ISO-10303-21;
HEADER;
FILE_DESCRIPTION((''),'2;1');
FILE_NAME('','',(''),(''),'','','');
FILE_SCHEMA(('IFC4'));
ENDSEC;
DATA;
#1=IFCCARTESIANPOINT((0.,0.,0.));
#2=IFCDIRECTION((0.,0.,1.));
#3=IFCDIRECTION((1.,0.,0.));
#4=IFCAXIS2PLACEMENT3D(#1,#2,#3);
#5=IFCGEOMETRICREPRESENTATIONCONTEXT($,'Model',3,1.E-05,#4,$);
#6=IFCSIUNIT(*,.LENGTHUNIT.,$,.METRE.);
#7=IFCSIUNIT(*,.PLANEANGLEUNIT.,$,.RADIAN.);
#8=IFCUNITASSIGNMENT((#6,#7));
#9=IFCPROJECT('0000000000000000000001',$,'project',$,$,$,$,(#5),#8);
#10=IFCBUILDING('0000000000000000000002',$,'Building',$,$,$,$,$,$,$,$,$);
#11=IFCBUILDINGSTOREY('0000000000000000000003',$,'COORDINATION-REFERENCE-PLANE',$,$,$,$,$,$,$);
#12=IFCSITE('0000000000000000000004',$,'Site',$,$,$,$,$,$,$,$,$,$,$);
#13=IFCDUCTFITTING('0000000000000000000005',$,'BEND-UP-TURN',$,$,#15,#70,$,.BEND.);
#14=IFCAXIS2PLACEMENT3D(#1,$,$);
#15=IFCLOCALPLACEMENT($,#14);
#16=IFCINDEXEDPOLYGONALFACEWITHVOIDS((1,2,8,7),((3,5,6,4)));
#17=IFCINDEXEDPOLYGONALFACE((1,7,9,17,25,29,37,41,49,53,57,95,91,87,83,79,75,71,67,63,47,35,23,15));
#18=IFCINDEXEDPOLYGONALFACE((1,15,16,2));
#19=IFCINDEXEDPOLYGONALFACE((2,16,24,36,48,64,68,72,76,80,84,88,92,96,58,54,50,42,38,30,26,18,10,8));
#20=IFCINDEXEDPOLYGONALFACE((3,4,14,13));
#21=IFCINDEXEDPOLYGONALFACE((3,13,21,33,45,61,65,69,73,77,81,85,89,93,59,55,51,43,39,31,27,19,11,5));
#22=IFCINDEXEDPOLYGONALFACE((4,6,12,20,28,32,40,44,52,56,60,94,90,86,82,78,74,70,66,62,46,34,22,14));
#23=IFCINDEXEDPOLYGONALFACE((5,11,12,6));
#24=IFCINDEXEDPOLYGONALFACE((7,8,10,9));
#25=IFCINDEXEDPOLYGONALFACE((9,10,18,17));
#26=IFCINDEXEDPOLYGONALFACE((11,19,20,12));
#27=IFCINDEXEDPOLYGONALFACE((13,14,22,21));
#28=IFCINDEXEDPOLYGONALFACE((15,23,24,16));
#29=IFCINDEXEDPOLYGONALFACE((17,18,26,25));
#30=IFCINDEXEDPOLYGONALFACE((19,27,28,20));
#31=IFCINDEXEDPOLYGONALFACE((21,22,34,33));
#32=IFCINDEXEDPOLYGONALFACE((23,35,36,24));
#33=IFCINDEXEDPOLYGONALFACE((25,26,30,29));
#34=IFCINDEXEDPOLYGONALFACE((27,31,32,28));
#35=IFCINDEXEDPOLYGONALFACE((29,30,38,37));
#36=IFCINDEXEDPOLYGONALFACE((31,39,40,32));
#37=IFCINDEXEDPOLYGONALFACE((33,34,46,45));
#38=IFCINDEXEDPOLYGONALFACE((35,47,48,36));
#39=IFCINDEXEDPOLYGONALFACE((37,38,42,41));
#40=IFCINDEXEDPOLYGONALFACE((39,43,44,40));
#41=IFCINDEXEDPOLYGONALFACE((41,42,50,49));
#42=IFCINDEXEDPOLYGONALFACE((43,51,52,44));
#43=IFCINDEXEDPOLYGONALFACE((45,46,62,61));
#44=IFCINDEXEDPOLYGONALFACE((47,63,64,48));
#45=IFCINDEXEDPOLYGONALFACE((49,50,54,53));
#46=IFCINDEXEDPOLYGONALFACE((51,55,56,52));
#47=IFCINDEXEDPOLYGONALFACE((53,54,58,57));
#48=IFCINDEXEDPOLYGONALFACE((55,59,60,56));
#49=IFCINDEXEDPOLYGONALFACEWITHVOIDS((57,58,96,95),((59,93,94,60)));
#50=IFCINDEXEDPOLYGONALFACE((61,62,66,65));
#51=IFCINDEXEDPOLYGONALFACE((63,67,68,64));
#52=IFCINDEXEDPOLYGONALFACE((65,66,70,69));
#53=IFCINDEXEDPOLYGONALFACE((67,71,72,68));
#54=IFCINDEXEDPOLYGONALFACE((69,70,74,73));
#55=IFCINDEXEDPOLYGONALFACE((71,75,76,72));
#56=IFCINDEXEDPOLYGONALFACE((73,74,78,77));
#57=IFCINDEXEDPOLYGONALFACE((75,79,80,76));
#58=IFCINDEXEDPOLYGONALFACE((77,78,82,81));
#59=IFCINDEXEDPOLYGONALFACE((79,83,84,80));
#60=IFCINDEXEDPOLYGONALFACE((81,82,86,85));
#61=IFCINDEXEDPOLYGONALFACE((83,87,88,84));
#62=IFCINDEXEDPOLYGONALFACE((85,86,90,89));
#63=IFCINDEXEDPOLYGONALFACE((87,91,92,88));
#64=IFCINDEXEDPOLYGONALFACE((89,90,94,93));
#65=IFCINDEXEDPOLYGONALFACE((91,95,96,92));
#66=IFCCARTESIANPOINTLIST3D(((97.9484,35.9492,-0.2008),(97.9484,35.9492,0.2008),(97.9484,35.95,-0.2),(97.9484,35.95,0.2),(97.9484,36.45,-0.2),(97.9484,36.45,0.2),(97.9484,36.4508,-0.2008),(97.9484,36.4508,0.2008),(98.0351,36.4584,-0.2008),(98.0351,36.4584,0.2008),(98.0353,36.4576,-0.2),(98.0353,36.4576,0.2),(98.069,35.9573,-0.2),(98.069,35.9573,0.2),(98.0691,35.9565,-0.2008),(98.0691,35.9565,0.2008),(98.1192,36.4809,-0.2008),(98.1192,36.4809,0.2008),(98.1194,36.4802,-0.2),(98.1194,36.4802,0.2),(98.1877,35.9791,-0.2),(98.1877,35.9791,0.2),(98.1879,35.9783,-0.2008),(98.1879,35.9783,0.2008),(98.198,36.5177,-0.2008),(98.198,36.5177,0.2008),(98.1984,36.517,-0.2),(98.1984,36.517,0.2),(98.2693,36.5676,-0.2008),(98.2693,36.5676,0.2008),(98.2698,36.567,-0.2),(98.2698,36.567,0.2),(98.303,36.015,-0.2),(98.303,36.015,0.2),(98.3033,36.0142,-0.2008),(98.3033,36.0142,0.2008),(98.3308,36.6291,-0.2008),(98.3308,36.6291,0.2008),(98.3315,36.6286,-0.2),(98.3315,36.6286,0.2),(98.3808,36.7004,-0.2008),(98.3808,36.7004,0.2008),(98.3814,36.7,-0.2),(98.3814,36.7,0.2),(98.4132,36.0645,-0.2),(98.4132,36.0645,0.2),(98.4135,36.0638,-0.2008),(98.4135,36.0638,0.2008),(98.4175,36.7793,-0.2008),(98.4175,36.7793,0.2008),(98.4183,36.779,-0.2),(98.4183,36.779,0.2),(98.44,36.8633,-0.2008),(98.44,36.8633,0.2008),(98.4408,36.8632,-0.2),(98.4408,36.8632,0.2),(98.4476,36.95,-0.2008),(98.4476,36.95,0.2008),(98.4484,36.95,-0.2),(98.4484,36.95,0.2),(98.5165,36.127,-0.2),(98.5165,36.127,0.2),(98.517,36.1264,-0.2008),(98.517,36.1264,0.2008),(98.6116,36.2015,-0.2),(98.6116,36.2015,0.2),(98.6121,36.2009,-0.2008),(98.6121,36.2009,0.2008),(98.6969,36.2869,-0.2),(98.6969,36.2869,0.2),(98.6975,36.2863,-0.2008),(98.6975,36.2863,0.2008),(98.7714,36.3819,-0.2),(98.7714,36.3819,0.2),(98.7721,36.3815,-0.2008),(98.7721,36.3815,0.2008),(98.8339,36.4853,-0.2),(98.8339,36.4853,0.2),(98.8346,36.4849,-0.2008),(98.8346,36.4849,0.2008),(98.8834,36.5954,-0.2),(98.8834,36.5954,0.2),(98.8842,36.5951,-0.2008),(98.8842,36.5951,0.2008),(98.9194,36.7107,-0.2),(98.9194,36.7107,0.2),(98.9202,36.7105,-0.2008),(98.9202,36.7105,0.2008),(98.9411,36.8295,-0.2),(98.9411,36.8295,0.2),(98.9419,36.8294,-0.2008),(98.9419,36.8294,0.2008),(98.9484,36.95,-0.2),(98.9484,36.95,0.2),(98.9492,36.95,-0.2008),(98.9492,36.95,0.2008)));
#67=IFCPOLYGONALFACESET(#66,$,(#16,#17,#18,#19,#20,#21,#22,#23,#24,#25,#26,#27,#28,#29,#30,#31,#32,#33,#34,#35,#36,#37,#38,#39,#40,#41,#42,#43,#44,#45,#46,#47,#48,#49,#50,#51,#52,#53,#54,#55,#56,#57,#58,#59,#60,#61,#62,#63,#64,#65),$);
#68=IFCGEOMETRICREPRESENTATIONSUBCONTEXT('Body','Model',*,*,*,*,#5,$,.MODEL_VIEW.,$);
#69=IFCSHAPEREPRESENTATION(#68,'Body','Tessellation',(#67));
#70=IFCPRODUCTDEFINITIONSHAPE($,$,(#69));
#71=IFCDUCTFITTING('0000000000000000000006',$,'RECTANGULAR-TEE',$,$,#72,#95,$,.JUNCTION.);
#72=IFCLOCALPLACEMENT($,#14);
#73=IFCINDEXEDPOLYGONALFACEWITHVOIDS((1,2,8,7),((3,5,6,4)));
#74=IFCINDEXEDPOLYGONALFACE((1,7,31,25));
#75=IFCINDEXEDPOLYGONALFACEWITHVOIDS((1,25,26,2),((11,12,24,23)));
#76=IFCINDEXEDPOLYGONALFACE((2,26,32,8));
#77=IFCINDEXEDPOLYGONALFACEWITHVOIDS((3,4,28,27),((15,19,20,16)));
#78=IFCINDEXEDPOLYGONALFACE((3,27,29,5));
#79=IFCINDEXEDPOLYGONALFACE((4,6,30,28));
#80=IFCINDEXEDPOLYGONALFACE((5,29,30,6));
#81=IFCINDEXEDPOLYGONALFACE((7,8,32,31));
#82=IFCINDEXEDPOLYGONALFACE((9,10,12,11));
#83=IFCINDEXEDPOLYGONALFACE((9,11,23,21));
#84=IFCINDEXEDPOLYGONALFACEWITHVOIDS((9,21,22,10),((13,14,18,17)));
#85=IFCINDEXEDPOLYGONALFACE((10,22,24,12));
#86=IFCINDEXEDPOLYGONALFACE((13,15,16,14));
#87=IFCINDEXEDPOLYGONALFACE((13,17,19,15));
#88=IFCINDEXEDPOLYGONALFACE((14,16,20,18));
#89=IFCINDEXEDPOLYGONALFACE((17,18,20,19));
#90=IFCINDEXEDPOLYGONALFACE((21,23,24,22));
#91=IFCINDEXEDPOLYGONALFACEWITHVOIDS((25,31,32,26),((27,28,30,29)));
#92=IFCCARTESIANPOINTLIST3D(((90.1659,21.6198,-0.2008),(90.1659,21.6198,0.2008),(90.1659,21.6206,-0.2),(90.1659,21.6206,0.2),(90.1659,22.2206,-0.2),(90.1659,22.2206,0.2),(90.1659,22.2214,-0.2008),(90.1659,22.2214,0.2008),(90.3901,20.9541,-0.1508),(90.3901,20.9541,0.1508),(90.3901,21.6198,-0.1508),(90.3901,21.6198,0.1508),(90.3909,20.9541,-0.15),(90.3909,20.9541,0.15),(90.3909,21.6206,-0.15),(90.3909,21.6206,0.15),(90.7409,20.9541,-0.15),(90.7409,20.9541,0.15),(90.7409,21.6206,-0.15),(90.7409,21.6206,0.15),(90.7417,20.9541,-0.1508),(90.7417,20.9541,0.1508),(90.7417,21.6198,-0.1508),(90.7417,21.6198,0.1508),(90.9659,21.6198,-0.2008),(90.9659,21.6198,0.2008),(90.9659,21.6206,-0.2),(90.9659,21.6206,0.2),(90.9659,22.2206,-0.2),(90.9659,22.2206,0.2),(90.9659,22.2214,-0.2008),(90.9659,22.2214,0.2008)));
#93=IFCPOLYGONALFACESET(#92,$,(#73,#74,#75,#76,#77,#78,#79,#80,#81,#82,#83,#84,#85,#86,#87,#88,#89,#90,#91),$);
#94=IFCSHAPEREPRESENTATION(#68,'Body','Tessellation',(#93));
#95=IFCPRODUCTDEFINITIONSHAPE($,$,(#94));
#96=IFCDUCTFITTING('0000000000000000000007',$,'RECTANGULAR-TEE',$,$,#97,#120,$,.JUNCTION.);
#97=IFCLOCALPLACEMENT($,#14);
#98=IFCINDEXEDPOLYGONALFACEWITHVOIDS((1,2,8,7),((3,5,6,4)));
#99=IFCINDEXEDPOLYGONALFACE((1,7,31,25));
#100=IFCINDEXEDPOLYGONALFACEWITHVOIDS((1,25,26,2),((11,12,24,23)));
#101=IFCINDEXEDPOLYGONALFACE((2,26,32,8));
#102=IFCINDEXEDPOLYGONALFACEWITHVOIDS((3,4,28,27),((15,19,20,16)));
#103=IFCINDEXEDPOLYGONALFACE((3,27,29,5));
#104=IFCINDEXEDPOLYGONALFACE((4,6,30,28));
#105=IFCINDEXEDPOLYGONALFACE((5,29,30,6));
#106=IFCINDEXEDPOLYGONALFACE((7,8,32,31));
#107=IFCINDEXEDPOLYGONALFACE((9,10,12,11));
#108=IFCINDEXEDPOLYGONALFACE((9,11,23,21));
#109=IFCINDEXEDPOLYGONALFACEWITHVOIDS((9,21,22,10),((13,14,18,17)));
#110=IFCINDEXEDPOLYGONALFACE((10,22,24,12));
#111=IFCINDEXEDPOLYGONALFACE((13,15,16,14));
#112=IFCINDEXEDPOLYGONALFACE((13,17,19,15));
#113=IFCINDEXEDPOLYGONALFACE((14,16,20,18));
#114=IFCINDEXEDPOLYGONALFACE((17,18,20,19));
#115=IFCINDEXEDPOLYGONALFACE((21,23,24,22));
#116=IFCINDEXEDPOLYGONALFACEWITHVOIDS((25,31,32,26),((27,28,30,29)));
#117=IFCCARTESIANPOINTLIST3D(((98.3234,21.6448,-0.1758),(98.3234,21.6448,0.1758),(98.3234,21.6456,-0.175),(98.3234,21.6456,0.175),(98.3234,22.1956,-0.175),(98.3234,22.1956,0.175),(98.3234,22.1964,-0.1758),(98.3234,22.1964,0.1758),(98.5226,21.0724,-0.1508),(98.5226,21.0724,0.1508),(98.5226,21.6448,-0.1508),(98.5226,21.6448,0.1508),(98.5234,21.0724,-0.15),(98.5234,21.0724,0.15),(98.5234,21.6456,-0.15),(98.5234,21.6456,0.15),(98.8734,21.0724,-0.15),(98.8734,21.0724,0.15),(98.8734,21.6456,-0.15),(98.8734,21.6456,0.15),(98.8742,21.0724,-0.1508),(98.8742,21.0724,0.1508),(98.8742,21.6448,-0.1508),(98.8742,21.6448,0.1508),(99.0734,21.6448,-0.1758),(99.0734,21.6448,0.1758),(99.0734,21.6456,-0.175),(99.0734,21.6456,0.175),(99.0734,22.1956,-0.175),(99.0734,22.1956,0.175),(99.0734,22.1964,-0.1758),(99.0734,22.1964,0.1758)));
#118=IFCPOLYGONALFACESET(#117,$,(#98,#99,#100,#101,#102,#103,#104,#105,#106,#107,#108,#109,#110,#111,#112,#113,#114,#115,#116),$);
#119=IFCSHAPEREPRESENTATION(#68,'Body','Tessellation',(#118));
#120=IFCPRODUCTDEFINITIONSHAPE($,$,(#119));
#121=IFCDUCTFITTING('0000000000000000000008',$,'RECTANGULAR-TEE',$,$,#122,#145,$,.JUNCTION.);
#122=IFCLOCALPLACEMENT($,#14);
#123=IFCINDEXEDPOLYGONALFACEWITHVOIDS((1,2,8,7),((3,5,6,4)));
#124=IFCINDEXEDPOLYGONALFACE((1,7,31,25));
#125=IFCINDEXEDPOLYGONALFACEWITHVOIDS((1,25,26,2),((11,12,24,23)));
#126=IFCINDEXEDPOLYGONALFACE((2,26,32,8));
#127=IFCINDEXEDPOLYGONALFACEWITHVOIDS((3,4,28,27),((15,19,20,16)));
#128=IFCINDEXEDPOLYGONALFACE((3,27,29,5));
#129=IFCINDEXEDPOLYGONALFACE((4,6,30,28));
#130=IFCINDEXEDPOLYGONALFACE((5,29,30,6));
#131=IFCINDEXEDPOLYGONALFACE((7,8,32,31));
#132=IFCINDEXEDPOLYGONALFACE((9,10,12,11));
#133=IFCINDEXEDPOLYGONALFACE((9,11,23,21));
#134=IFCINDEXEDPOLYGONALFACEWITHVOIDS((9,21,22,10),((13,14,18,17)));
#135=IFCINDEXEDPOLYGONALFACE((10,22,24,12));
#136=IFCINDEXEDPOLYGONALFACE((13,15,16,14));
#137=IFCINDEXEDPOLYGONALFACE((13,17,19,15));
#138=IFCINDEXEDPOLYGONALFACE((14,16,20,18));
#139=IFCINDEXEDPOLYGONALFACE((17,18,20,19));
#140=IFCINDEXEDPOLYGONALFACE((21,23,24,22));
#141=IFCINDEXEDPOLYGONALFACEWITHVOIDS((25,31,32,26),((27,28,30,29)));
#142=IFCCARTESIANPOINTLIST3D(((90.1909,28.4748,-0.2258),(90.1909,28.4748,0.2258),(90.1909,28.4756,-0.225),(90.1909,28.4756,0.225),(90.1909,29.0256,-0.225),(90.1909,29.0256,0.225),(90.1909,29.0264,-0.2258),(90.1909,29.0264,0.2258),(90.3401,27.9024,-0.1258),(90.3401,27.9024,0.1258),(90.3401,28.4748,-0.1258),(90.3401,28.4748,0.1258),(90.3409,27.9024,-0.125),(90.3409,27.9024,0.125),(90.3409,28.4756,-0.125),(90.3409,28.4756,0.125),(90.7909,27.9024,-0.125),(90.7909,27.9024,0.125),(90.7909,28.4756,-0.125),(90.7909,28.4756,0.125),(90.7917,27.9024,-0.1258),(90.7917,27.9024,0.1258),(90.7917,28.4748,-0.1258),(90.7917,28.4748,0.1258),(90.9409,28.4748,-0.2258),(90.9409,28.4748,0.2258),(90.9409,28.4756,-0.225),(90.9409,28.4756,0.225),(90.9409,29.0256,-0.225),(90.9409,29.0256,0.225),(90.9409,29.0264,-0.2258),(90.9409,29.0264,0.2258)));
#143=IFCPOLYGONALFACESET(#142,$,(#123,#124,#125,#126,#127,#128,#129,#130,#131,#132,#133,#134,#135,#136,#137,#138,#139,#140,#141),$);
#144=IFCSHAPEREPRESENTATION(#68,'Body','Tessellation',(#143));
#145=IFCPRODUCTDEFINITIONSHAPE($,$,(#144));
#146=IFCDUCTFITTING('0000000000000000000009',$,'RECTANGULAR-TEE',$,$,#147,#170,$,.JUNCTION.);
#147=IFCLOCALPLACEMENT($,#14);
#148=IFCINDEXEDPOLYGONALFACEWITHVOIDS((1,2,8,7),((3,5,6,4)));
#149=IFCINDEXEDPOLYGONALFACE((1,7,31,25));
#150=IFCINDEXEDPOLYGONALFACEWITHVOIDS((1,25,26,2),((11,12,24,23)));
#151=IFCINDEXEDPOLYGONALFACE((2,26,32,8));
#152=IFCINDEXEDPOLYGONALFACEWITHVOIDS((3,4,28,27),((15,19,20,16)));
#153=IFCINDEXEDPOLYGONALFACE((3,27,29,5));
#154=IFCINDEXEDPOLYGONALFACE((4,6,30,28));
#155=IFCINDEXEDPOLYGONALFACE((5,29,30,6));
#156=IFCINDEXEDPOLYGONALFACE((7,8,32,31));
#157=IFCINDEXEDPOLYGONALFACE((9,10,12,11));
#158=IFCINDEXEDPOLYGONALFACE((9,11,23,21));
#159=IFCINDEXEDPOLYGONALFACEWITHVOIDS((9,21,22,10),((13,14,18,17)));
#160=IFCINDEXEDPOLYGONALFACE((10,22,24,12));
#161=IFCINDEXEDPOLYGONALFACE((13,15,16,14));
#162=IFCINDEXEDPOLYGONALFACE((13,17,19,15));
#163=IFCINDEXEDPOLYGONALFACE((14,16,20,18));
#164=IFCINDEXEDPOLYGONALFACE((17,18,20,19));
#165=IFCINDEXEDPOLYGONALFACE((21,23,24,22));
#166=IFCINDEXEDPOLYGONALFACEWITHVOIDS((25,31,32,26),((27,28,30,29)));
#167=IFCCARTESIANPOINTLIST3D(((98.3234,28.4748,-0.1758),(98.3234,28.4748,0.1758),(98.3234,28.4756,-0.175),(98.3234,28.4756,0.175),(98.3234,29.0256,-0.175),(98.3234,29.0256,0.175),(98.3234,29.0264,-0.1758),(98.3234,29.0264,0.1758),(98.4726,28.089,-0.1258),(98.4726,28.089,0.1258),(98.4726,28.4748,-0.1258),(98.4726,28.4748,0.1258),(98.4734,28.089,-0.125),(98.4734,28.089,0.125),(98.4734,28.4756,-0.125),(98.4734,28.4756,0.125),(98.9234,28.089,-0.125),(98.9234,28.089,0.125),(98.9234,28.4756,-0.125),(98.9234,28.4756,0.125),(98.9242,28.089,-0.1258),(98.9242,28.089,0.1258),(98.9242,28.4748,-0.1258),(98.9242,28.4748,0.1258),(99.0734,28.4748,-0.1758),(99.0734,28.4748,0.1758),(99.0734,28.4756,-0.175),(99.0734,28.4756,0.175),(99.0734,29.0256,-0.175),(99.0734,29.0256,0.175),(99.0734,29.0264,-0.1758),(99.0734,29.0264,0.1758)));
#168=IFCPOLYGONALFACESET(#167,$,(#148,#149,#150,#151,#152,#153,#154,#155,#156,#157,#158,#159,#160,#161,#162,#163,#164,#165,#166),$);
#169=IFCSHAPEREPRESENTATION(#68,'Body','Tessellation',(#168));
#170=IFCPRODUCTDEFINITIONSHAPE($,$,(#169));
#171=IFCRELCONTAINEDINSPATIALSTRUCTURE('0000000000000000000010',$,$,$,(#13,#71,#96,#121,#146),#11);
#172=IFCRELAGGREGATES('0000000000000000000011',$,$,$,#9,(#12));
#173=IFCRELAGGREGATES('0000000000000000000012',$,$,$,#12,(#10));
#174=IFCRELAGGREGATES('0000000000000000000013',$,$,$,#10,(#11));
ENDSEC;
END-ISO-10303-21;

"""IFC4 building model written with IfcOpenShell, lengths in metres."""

from ifc_helpers import new_model, entity, si_unit, frame, origin_with_axes, place, context, subcontext, project, spatial, rectangle, extrude, boolean, element, save


model = new_model("IFC4")

# Units and contexts
model_context = context("Model", 3, precision=1e-05, world=origin_with_axes())
body_context = subcontext(model_context, "Body", "Model", "MODEL_VIEW")
ifc_project = project(units=[si_unit("LENGTHUNIT", "METRE"), si_unit("PLANEANGLEUNIT", "RADIAN")], contexts=[model_context])

# Site, building, storey
site = spatial("IfcSite", under=ifc_project, Name="Site")
building = spatial("IfcBuilding", under=site, Name="Building")
storey = spatial("IfcBuildingStorey", under=building, Name="COORDINATION-REFERENCE-PLANE")

# Duct fittings
duct_fitting_1_placement = place(None, frame((97.9484, 36.95, 0.0), z_axis=(0.0, 0.0, 1.0), x_axis=(0.0, -1.0, 0.0)))
cartesian_point_1 = entity("IfcCartesianPoint", [0.0, 0.0, 0.0])
element("IfcDuctFitting", 1, at=duct_fitting_1_placement, inside=storey, Name="BEND-UP-TURN", PredefinedType="BEND", context=body_context, shape_type="SweptSolid", body=[
    entity("IfcRevolvedAreaSolid", entity("IfcRectangleHollowProfileDef", "AREA", None, entity("IfcAxis2Placement2D", entity("IfcCartesianPoint", [0.75, 0.0])), 0.5016, 0.4016, 0.0008), entity("IfcAxis2Placement3D", cartesian_point_1, entity("IfcDirection", [0.0, -1.0, 0.0]), entity("IfcDirection", [1.0, 0.0, 0.0])), entity("IfcAxis1Placement", cartesian_point_1, entity("IfcDirection", [0.0, 1.0, 0.0])), 1.570796),
])
duct_fitting_2_placement = place(None, frame((90.5659, 21.9206, 0.0), z_axis=(1.0, 0.0, 0.0), x_axis=(0.0, -1.0, 0.0)))
solid_1 = boolean("UNION", extrude(rectangle(XDim=0.6, YDim=0.4), frame((0.0, 0.0, -0.4), z_axis=(0.0, 0.0, 1.0), x_axis=(1.0, 0.0, 0.0)), (0.0, 0.0, 1.0), 0.8), extrude(rectangle(XDim=0.35, YDim=0.3), frame((0.0, 0.0, 0.0), z_axis=(1.0, 0.0, 0.0), x_axis=(0.0, 0.0, -1.0)), (0.0, 0.0, 1.0), 0.9665))
element("IfcDuctFitting", 2, at=duct_fitting_2_placement, inside=storey, Name="RECTANGULAR-TEE", PredefinedType="JUNCTION", context=body_context, shape_type="CSG", body=[
    boolean("DIFFERENCE", boolean("UNION", extrude(rectangle(XDim=0.6016, YDim=0.4016), frame((0.0, 0.0, -0.4), z_axis=(0.0, 0.0, 1.0), x_axis=(1.0, 0.0, 0.0)), (0.0, 0.0, 1.0), 0.8), extrude(rectangle(XDim=0.3516, YDim=0.3016), frame((0.0, 0.0, 0.0), z_axis=(1.0, 0.0, 0.0), x_axis=(0.0, 0.0, -1.0)), (0.0, 0.0, 1.0), 0.9665)), solid_1),
])
duct_fitting_3_placement = place(None, frame((98.6984, 21.9206, 0.0), z_axis=(1.0, 0.0, 0.0), x_axis=(0.0, -1.0, 0.0)))
solid_2 = boolean("UNION", extrude(rectangle(XDim=0.55, YDim=0.35), frame((0.0, 0.0, -0.375), z_axis=(0.0, 0.0, 1.0), x_axis=(1.0, 0.0, 0.0)), (0.0, 0.0, 1.0), 0.75), extrude(rectangle(XDim=0.35, YDim=0.3), frame((0.0, 0.0, 0.0), z_axis=(1.0, 0.0, 0.0), x_axis=(0.0, 0.0, -1.0)), (0.0, 0.0, 1.0), 0.8482))
element("IfcDuctFitting", 3, at=duct_fitting_3_placement, inside=storey, Name="RECTANGULAR-TEE", PredefinedType="JUNCTION", context=body_context, shape_type="CSG", body=[
    boolean("DIFFERENCE", boolean("UNION", extrude(rectangle(XDim=0.5516, YDim=0.3516), frame((0.0, 0.0, -0.375), z_axis=(0.0, 0.0, 1.0), x_axis=(1.0, 0.0, 0.0)), (0.0, 0.0, 1.0), 0.75), extrude(rectangle(XDim=0.3516, YDim=0.3016), frame((0.0, 0.0, 0.0), z_axis=(1.0, 0.0, 0.0), x_axis=(0.0, 0.0, -1.0)), (0.0, 0.0, 1.0), 0.8482)), solid_2),
])
duct_fitting_4_placement = place(None, frame((90.5659, 28.7506, 0.0), z_axis=(1.0, 0.0, 0.0), x_axis=(0.0, -1.0, 0.0)))
solid_3 = boolean("UNION", extrude(rectangle(XDim=0.55, YDim=0.45), frame((0.0, 0.0, -0.375), z_axis=(0.0, 0.0, 1.0), x_axis=(1.0, 0.0, 0.0)), (0.0, 0.0, 1.0), 0.75), extrude(rectangle(XDim=0.45, YDim=0.25), frame((0.0, 0.0, 0.0), z_axis=(1.0, 0.0, 0.0), x_axis=(0.0, 0.0, -1.0)), (0.0, 0.0, 1.0), 0.8482))
element("IfcDuctFitting", 4, at=duct_fitting_4_placement, inside=storey, Name="RECTANGULAR-TEE", PredefinedType="JUNCTION", context=body_context, shape_type="CSG", body=[
    boolean("DIFFERENCE", boolean("UNION", extrude(rectangle(XDim=0.5516, YDim=0.4516), frame((0.0, 0.0, -0.375), z_axis=(0.0, 0.0, 1.0), x_axis=(1.0, 0.0, 0.0)), (0.0, 0.0, 1.0), 0.75), extrude(rectangle(XDim=0.4516, YDim=0.2516), frame((0.0, 0.0, 0.0), z_axis=(1.0, 0.0, 0.0), x_axis=(0.0, 0.0, -1.0)), (0.0, 0.0, 1.0), 0.8482)), solid_3),
])
duct_fitting_5_placement = place(None, frame((98.6984, 28.7506, 0.0), z_axis=(1.0, 0.0, 0.0), x_axis=(0.0, -1.0, 0.0)))
solid_4 = boolean("UNION", extrude(rectangle(XDim=0.55, YDim=0.35), frame((0.0, 0.0, -0.375), z_axis=(0.0, 0.0, 1.0), x_axis=(1.0, 0.0, 0.0)), (0.0, 0.0, 1.0), 0.75), extrude(rectangle(XDim=0.45, YDim=0.25), frame((0.0, 0.0, 0.0), z_axis=(1.0, 0.0, 0.0), x_axis=(0.0, 0.0, -1.0)), (0.0, 0.0, 1.0), 0.6616))
element("IfcDuctFitting", 5, at=duct_fitting_5_placement, inside=storey, Name="RECTANGULAR-TEE", PredefinedType="JUNCTION", context=body_context, shape_type="CSG", body=[
    boolean("DIFFERENCE", boolean("UNION", extrude(rectangle(XDim=0.5516, YDim=0.3516), frame((0.0, 0.0, -0.375), z_axis=(0.0, 0.0, 1.0), x_axis=(1.0, 0.0, 0.0)), (0.0, 0.0, 1.0), 0.75), extrude(rectangle(XDim=0.4516, YDim=0.2516), frame((0.0, 0.0, 0.0), z_axis=(1.0, 0.0, 0.0), x_axis=(0.0, 0.0, -1.0)), (0.0, 0.0, 1.0), 0.6616)), solid_4),
])

save(model, "model.ifc")
